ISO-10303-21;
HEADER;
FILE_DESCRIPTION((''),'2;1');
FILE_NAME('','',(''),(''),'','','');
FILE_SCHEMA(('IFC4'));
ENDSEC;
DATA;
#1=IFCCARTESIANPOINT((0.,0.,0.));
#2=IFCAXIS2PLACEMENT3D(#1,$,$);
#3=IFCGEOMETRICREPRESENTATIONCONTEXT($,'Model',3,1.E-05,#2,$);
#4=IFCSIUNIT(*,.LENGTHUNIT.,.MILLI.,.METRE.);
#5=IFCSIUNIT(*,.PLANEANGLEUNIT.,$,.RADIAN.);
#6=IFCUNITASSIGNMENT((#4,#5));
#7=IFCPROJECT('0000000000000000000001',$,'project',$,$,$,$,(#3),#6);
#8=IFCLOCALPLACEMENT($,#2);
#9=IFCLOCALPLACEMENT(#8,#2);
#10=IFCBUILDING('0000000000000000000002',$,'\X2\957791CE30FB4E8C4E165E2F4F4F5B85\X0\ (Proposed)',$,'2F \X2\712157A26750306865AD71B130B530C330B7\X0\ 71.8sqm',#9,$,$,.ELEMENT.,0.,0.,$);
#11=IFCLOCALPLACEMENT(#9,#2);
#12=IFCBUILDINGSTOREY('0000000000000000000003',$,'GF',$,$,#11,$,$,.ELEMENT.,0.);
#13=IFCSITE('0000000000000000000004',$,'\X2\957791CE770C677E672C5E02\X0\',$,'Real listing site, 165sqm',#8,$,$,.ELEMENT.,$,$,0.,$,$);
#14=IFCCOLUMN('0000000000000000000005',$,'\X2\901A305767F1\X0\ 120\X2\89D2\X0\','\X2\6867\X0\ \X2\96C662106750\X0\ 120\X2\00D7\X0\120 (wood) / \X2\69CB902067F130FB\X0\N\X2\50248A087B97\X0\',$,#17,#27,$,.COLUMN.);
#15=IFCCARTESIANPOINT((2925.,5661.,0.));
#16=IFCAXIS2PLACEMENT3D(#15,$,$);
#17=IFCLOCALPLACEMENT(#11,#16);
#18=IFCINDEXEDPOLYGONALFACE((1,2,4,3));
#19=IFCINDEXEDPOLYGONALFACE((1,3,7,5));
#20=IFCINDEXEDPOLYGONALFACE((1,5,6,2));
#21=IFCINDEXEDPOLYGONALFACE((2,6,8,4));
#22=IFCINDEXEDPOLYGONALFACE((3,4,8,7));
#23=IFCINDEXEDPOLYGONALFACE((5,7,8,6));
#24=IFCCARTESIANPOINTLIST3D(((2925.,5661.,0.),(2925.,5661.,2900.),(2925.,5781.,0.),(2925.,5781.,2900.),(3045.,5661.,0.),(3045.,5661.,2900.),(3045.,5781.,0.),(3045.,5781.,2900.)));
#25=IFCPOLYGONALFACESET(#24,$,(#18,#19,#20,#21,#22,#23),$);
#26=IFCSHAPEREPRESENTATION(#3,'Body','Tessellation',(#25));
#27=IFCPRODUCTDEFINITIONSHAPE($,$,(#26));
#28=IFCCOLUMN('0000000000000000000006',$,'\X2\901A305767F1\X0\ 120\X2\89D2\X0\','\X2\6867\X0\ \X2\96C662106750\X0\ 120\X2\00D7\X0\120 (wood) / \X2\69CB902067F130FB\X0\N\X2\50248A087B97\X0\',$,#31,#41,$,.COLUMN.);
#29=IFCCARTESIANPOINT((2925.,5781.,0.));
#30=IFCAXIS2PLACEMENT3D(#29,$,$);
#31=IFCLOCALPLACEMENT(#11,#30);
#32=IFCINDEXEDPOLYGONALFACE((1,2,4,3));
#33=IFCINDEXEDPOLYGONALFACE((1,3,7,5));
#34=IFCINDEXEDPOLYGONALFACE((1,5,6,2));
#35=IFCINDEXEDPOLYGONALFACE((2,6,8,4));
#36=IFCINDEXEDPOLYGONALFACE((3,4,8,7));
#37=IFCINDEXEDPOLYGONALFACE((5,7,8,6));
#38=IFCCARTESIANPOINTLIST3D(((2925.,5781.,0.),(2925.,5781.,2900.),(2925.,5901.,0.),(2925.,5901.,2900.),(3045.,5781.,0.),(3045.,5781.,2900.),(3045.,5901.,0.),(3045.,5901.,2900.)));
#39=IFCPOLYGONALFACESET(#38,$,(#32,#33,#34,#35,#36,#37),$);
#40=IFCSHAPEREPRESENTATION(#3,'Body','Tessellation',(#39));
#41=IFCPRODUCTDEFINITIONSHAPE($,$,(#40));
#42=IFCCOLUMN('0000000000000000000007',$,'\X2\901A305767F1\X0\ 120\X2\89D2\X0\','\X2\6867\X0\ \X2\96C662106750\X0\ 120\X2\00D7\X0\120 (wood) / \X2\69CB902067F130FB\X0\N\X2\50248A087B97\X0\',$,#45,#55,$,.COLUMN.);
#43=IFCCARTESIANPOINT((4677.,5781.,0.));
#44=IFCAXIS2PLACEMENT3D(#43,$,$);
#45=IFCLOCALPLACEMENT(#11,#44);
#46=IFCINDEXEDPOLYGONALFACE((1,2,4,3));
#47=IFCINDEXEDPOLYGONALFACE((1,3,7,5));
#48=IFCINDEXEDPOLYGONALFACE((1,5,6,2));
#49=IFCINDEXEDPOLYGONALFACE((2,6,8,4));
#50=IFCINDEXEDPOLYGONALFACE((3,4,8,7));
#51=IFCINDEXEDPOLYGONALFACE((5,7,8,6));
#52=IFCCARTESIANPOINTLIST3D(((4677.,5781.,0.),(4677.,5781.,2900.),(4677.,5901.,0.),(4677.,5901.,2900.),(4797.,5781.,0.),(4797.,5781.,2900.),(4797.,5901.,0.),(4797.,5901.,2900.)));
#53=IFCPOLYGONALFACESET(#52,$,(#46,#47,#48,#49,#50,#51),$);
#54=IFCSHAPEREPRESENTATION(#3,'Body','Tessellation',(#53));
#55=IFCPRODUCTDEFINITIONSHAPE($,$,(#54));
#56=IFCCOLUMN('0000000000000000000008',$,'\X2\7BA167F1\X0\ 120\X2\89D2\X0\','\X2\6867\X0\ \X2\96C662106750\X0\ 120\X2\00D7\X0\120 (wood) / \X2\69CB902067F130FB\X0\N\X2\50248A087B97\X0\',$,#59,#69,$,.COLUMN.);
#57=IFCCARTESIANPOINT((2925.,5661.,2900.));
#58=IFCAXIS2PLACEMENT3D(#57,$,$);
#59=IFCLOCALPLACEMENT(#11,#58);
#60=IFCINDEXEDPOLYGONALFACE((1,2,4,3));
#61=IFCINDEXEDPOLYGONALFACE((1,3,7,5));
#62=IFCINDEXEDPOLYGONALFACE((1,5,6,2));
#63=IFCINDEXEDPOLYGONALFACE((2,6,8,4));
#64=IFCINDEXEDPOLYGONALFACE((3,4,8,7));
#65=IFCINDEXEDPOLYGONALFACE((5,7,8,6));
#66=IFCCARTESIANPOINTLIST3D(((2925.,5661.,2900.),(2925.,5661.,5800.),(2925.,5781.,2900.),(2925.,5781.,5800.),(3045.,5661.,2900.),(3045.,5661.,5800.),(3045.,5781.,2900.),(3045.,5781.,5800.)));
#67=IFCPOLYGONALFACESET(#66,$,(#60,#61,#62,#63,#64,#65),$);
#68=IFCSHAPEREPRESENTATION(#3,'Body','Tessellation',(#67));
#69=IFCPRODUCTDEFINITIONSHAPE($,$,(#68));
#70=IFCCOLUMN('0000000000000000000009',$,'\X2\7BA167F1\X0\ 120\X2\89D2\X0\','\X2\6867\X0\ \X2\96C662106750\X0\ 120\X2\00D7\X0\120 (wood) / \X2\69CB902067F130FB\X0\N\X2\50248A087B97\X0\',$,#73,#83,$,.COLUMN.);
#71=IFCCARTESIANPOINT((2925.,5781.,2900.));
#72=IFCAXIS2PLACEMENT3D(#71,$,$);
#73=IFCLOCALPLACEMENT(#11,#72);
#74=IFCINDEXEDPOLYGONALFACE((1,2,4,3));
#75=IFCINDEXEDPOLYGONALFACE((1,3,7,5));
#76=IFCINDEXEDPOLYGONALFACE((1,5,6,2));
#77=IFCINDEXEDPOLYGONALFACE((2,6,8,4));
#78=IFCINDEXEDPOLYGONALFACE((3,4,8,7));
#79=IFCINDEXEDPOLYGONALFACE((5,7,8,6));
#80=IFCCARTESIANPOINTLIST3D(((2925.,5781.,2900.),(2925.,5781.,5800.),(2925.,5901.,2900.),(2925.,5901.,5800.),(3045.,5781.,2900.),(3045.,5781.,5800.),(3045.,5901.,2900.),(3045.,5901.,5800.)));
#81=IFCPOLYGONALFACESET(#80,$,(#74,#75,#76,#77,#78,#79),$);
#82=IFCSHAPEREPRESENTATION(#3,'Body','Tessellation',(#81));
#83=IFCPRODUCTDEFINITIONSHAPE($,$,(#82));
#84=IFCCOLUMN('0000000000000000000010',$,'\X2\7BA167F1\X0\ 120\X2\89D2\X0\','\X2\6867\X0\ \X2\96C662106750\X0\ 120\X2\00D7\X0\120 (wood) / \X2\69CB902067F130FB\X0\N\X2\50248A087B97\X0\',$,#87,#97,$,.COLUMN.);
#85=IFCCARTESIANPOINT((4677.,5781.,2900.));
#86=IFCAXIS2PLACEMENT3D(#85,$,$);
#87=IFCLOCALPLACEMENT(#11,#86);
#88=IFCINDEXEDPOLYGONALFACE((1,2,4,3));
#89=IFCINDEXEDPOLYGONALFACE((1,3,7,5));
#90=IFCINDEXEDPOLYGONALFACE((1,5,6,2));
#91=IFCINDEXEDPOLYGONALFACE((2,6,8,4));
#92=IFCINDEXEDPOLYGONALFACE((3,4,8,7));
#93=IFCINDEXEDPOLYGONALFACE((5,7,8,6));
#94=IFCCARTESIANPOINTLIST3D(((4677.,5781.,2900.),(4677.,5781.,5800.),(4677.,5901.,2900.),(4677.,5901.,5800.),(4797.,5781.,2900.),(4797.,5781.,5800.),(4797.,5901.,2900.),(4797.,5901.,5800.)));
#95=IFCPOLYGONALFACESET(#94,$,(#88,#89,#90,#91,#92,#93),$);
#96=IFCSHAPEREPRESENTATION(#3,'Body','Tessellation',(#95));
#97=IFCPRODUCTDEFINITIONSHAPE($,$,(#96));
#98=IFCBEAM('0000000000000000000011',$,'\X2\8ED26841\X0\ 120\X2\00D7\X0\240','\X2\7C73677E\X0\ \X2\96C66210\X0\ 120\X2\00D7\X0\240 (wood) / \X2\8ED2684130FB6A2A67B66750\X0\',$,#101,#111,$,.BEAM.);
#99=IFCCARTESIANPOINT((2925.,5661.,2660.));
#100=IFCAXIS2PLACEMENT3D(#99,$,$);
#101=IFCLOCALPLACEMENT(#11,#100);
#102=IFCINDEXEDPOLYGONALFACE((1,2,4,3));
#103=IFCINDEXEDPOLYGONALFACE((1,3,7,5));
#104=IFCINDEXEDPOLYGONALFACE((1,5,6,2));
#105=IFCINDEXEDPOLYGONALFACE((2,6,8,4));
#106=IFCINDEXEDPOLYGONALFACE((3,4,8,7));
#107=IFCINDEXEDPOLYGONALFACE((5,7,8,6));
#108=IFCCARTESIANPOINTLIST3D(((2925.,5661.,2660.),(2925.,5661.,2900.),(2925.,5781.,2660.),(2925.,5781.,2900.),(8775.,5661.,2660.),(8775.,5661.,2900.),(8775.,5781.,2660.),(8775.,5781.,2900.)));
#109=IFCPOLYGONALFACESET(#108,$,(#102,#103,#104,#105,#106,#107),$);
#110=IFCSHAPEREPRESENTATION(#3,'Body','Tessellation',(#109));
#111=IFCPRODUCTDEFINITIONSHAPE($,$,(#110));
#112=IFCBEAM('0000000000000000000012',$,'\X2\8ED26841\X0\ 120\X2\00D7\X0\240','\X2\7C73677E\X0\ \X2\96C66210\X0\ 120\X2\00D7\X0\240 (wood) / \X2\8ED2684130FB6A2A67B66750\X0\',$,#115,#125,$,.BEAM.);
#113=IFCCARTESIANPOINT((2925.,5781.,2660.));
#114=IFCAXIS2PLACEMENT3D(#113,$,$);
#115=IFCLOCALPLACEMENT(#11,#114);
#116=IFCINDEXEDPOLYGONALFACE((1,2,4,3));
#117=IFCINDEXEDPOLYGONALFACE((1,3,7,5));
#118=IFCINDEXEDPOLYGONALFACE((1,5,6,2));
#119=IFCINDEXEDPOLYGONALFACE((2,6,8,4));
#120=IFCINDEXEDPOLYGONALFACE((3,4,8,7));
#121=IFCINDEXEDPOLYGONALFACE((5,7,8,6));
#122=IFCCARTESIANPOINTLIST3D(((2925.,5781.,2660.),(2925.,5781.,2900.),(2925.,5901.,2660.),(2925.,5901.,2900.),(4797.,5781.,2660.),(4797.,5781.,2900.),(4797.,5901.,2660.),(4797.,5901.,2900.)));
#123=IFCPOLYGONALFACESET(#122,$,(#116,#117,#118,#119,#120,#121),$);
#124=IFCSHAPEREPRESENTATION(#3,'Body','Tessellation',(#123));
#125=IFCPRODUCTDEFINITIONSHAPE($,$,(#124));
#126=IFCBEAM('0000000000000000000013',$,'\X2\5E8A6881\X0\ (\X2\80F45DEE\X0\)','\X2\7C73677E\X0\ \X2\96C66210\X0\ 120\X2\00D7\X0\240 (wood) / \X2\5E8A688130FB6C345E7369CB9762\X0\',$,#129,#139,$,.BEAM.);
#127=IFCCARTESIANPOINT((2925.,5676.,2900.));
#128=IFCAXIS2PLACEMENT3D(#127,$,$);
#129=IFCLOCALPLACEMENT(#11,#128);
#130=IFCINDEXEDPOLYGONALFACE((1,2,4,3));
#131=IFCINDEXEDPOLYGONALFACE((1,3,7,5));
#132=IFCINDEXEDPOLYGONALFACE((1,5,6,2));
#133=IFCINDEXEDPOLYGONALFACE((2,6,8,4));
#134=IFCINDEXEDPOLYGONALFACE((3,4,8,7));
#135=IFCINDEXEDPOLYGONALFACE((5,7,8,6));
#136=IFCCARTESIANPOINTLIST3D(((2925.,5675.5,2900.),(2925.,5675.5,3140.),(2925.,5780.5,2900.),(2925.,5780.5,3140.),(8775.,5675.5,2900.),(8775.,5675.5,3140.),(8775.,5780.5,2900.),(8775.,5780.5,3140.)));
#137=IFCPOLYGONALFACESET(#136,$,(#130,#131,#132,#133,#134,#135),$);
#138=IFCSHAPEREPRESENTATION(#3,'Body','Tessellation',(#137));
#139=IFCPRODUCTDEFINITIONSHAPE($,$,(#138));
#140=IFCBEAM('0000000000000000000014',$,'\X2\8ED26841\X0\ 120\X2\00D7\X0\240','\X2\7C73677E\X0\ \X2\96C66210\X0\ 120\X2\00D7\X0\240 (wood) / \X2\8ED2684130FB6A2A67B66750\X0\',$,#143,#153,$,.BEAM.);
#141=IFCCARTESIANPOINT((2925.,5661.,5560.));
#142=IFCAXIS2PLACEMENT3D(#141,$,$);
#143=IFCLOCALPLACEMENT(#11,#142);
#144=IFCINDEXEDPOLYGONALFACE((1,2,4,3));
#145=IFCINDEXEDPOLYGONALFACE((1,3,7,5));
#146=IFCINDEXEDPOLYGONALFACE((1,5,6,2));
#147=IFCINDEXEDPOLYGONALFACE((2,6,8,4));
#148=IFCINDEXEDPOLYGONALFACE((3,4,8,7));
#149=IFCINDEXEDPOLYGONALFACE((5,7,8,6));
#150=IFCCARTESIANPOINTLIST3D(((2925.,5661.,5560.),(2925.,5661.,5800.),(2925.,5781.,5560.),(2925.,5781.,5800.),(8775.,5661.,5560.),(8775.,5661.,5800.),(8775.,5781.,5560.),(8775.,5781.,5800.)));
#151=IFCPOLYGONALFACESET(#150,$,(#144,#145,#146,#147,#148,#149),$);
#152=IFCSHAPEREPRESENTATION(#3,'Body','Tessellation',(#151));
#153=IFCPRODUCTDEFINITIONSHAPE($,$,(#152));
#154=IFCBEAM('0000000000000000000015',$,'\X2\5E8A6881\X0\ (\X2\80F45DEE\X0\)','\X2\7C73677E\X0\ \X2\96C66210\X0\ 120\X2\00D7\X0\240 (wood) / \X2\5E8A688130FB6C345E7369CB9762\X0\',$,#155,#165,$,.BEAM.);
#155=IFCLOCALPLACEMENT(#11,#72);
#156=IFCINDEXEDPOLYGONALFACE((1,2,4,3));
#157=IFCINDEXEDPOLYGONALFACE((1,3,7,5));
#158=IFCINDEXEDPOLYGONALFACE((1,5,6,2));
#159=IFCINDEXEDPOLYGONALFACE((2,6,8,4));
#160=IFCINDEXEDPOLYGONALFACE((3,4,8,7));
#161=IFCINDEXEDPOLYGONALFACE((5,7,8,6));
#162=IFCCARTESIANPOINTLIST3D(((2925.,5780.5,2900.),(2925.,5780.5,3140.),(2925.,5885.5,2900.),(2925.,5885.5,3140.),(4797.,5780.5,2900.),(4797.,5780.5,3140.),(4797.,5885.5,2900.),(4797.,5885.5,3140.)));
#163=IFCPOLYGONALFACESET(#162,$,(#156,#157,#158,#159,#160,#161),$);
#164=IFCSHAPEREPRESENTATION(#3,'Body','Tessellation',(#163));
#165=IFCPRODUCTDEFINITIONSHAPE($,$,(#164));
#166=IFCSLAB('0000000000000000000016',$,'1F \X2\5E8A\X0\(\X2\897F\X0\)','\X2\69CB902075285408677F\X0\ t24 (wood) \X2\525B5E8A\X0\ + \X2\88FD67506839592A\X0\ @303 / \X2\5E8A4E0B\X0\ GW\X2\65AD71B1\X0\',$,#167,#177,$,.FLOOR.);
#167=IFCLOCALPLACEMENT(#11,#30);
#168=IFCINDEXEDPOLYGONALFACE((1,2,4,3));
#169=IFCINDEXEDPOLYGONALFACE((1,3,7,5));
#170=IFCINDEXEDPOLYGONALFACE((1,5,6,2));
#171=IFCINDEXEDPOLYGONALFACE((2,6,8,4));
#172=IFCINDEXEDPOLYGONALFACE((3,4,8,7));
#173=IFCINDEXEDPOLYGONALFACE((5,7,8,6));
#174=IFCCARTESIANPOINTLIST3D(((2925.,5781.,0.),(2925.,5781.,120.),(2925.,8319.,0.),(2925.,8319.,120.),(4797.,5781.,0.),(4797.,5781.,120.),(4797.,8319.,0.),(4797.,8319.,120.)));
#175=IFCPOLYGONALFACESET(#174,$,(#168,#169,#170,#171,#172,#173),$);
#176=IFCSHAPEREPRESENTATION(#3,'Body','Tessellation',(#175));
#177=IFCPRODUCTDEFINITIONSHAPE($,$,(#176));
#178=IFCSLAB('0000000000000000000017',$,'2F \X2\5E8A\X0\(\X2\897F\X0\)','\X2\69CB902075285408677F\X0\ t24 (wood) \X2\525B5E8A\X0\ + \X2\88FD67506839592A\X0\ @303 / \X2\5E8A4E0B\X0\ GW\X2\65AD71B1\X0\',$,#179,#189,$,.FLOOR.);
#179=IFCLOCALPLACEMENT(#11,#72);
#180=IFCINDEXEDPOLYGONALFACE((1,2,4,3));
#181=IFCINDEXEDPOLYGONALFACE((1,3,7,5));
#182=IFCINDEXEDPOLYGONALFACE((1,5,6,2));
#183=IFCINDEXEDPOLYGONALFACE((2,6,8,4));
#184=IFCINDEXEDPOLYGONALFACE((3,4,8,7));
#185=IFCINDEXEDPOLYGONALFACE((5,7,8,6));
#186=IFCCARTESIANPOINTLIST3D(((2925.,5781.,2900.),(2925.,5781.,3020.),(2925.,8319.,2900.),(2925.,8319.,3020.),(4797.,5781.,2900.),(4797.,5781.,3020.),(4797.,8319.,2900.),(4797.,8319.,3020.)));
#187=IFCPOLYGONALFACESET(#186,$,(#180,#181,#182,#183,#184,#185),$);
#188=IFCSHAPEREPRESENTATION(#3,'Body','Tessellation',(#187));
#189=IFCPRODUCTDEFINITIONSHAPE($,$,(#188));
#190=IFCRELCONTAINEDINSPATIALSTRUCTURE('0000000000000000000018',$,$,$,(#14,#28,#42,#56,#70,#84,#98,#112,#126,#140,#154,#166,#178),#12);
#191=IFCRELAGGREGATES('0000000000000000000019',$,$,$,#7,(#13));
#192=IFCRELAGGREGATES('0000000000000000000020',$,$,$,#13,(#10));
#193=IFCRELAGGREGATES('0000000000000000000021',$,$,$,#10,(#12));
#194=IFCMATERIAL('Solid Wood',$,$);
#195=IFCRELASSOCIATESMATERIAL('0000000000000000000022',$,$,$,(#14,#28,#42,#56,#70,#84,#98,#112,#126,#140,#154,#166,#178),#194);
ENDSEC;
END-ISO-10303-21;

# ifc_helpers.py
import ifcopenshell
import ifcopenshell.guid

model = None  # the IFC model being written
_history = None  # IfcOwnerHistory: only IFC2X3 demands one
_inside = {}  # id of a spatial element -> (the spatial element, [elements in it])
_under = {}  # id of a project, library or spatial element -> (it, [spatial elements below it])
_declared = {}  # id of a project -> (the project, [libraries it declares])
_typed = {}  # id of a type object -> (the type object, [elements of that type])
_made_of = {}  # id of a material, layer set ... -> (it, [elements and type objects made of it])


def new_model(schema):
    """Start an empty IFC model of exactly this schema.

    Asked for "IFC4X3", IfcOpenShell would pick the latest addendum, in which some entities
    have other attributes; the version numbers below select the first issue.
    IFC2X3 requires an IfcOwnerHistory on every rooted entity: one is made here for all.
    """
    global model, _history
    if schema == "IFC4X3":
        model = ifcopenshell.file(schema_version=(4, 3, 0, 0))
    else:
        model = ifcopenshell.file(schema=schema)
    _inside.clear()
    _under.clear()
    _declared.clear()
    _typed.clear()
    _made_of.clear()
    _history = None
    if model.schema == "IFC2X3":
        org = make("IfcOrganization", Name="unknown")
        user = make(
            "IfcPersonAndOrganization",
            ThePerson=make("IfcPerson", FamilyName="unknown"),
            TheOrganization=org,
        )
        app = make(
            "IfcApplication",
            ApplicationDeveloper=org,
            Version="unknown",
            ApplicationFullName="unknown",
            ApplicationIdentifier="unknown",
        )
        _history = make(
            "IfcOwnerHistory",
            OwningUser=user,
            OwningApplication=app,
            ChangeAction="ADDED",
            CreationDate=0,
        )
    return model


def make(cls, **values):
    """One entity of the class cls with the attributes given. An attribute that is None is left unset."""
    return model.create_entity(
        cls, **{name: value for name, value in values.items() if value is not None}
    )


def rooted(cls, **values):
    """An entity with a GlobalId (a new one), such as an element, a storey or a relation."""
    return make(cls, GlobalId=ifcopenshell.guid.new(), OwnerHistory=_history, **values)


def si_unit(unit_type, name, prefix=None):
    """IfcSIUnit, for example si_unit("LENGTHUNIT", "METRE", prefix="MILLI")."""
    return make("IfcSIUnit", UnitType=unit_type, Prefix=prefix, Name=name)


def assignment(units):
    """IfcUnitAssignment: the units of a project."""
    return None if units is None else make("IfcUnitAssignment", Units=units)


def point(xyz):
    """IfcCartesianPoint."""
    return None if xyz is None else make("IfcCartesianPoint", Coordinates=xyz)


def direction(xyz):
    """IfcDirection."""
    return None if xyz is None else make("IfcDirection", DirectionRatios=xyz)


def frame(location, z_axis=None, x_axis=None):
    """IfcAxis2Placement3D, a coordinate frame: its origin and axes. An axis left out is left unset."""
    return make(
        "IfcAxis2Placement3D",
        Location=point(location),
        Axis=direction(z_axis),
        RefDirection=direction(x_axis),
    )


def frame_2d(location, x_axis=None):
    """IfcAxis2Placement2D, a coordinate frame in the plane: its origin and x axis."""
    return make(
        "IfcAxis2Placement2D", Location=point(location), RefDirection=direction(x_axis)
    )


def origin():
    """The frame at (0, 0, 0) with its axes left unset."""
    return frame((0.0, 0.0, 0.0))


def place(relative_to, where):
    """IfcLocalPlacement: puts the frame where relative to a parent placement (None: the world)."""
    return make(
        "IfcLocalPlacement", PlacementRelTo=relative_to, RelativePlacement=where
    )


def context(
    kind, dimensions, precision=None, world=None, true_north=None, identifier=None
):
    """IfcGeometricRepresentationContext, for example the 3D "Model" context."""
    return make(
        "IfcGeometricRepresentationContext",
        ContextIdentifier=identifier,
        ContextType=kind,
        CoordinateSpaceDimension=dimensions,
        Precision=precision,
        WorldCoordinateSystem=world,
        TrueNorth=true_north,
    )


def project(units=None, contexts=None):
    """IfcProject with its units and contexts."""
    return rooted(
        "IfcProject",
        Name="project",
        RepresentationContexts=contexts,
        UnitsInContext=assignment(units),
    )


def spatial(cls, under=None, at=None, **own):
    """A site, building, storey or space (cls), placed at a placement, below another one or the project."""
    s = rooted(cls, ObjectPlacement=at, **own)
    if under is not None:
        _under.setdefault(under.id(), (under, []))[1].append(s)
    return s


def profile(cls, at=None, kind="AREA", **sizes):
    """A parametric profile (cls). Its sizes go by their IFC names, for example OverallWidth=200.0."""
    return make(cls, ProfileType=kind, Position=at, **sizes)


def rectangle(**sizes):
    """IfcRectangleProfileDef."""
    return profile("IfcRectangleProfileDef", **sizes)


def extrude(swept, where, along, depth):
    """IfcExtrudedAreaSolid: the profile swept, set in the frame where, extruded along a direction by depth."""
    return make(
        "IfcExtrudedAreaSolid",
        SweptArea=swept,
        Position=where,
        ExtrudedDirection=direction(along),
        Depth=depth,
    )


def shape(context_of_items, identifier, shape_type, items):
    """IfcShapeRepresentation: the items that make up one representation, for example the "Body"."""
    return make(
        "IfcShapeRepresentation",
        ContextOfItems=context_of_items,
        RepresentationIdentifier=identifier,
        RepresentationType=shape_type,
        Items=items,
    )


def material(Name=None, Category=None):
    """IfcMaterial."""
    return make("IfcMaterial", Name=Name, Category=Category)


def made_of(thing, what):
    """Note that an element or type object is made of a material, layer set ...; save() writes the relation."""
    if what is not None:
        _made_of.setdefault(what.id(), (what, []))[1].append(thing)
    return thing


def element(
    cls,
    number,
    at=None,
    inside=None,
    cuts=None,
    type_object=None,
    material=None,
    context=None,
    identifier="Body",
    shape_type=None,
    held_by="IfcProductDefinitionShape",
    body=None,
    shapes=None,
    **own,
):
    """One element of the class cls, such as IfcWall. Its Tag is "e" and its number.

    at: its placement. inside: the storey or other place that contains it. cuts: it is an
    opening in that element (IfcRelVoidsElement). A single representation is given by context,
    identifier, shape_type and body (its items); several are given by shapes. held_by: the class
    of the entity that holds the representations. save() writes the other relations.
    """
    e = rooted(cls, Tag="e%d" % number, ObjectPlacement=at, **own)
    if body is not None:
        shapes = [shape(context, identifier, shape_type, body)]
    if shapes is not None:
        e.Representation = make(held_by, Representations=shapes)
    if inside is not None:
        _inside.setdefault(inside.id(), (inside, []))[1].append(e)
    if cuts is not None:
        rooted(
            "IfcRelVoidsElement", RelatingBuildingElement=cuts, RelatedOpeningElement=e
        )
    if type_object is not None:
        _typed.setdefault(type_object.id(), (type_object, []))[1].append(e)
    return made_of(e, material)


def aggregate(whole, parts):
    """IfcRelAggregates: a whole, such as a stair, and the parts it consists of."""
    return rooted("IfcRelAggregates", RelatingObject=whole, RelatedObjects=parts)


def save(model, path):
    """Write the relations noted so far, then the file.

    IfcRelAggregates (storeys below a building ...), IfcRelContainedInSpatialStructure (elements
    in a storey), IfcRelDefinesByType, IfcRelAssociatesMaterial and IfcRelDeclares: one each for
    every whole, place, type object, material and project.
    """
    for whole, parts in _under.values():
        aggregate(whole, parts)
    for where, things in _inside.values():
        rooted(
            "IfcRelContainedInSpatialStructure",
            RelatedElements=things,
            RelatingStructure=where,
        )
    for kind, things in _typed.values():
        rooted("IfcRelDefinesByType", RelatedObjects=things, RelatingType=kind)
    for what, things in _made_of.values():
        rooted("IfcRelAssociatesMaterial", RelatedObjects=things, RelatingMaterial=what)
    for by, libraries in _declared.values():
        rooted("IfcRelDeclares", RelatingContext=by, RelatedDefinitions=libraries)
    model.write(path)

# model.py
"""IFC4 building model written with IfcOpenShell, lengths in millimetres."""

from ifc_helpers import new_model, si_unit, frame, frame_2d, origin, place, context, project, spatial, rectangle, extrude, material, element, save


model = new_model("IFC4")

# Units and contexts
model_context = context("Model", 3, precision=1e-05, world=origin())
ifc_project = project(units=[si_unit("LENGTHUNIT", "METRE", prefix="MILLI"), si_unit("PLANEANGLEUNIT", "RADIAN")], contexts=[model_context])

# Site, building, storey
site_placement = place(None, origin())
site = spatial("IfcSite", under=ifc_project, at=site_placement, Name="長野県松本市", ObjectType="Real listing site, 165sqm", CompositionType="ELEMENT", RefElevation=0.0)
building_placement = place(site_placement, origin())
building = spatial("IfcBuilding", under=site, at=building_placement, Name="長野・二世帯住宅 (Proposed)", ObjectType="2F 無垢材と断熱サッシ 71.8sqm", CompositionType="ELEMENT", ElevationOfRefHeight=0.0, ElevationOfTerrain=0.0)
storey_placement = place(building_placement, origin())
storey = spatial("IfcBuildingStorey", under=building, at=storey_placement, Name="GF", CompositionType="ELEMENT", Elevation=0.0)

# Columns
ifc_material_1 = material(Name="Solid Wood")
column_1_placement = place(storey_placement, frame((2925.0, 5661.0, 0.0)))
element("IfcColumn", 1, at=column_1_placement, inside=storey, material=ifc_material_1, Name="通し柱 120角", Description="桧 集成材 120×120 (wood) / 構造柱・N値計算", PredefinedType="COLUMN", context=model_context, shape_type="SweptSolid", body=[
    extrude(rectangle(XDim=120.0, YDim=120.0, at=frame_2d((60.0, 60.0))), frame((2925.0, 5661.0, 0.0)), (0.0, 0.0, 1.0), 2900.0),
])
column_2_placement = place(storey_placement, frame((2925.0, 5781.0, 0.0)))
element("IfcColumn", 2, at=column_2_placement, inside=storey, material=ifc_material_1, Name="通し柱 120角", Description="桧 集成材 120×120 (wood) / 構造柱・N値計算", PredefinedType="COLUMN", context=model_context, shape_type="SweptSolid", body=[
    extrude(rectangle(XDim=120.0, YDim=120.0, at=frame_2d((60.0, 60.0))), frame((2925.0, 5781.0, 0.0)), (0.0, 0.0, 1.0), 2900.0),
])
column_3_placement = place(storey_placement, frame((4677.0, 5781.0, 0.0)))
element("IfcColumn", 3, at=column_3_placement, inside=storey, material=ifc_material_1, Name="通し柱 120角", Description="桧 集成材 120×120 (wood) / 構造柱・N値計算", PredefinedType="COLUMN", context=model_context, shape_type="SweptSolid", body=[
    extrude(rectangle(XDim=120.0, YDim=120.0, at=frame_2d((60.0, 60.0))), frame((4677.0, 5781.0, 0.0)), (0.0, 0.0, 1.0), 2900.0),
])
column_4_placement = place(storey_placement, frame((2925.0, 5661.0, 2900.0)))
element("IfcColumn", 4, at=column_4_placement, inside=storey, material=ifc_material_1, Name="管柱 120角", Description="桧 集成材 120×120 (wood) / 構造柱・N値計算", PredefinedType="COLUMN", context=model_context, shape_type="SweptSolid", body=[
    extrude(rectangle(XDim=120.0, YDim=120.0, at=frame_2d((60.0, 60.0))), frame((2925.0, 5661.0, 2900.0)), (0.0, 0.0, 1.0), 2900.0),
])
column_5_placement = place(storey_placement, frame((2925.0, 5781.0, 2900.0)))
element("IfcColumn", 5, at=column_5_placement, inside=storey, material=ifc_material_1, Name="管柱 120角", Description="桧 集成材 120×120 (wood) / 構造柱・N値計算", PredefinedType="COLUMN", context=model_context, shape_type="SweptSolid", body=[
    extrude(rectangle(XDim=120.0, YDim=120.0, at=frame_2d((60.0, 60.0))), frame((2925.0, 5781.0, 2900.0)), (0.0, 0.0, 1.0), 2900.0),
])
column_6_placement = place(storey_placement, frame((4677.0, 5781.0, 2900.0)))
element("IfcColumn", 6, at=column_6_placement, inside=storey, material=ifc_material_1, Name="管柱 120角", Description="桧 集成材 120×120 (wood) / 構造柱・N値計算", PredefinedType="COLUMN", context=model_context, shape_type="SweptSolid", body=[
    extrude(rectangle(XDim=120.0, YDim=120.0, at=frame_2d((60.0, 60.0))), frame((4677.0, 5781.0, 2900.0)), (0.0, 0.0, 1.0), 2900.0),
])

# Beams
beam_1_placement = place(storey_placement, frame((2925.0, 5661.0, 2660.0)))
element("IfcBeam", 7, at=beam_1_placement, inside=storey, material=ifc_material_1, Name="軒桁 120×240", Description="米松 集成 120×240 (wood) / 軒桁・横架材", PredefinedType="BEAM", context=model_context, shape_type="SweptSolid", body=[
    extrude(rectangle(XDim=5850.0, YDim=120.0, at=frame_2d((2925.0, 60.0))), frame((2925.0, 5661.0, 2660.0)), (0.0, 0.0, 1.0), 240.0),
])
beam_2_placement = place(storey_placement, frame((2925.0, 5781.0, 2660.0)))
element("IfcBeam", 8, at=beam_2_placement, inside=storey, material=ifc_material_1, Name="軒桁 120×240", Description="米松 集成 120×240 (wood) / 軒桁・横架材", PredefinedType="BEAM", context=model_context, shape_type="SweptSolid", body=[
    extrude(rectangle(XDim=1872.0, YDim=120.0, at=frame_2d((936.0, 60.0))), frame((2925.0, 5781.0, 2660.0)), (0.0, 0.0, 1.0), 240.0),
])
beam_3_placement = place(storey_placement, frame((2925.0, 5676.0, 2900.0)))
element("IfcBeam", 9, at=beam_3_placement, inside=storey, material=ifc_material_1, Name="床梁 (胴差)", Description="米松 集成 120×240 (wood) / 床梁・水平構面", PredefinedType="BEAM", context=model_context, shape_type="SweptSolid", body=[
    extrude(rectangle(XDim=5850.0, YDim=105.0, at=frame_2d((2925.0, 52.0))), frame((2925.0, 5676.0, 2900.0)), (0.0, 0.0, 1.0), 240.0),
])
beam_4_placement = place(storey_placement, frame((2925.0, 5661.0, 5560.0)))
element("IfcBeam", 10, at=beam_4_placement, inside=storey, material=ifc_material_1, Name="軒桁 120×240", Description="米松 集成 120×240 (wood) / 軒桁・横架材", PredefinedType="BEAM", context=model_context, shape_type="SweptSolid", body=[
    extrude(rectangle(XDim=5850.0, YDim=120.0, at=frame_2d((2925.0, 60.0))), frame((2925.0, 5661.0, 5560.0)), (0.0, 0.0, 1.0), 240.0),
])
beam_5_placement = place(storey_placement, frame((2925.0, 5781.0, 2900.0)))
element("IfcBeam", 11, at=beam_5_placement, inside=storey, material=ifc_material_1, Name="床梁 (胴差)", Description="米松 集成 120×240 (wood) / 床梁・水平構面", PredefinedType="BEAM", context=model_context, shape_type="SweptSolid", body=[
    extrude(rectangle(XDim=1872.0, YDim=105.0, at=frame_2d((936.0, 52.0))), frame((2925.0, 5781.0, 2900.0)), (0.0, 0.0, 1.0), 240.0),
])

# Slabs
slab_1_placement = place(storey_placement, frame((2925.0, 5781.0, 0.0)))
element("IfcSlab", 12, at=slab_1_placement, inside=storey, material=ifc_material_1, Name="1F 床(西)", Description="構造用合板 t24 (wood) 剛床 + 製材根太 @303 / 床下 GW断熱", PredefinedType="FLOOR", context=model_context, shape_type="SweptSolid", body=[
    extrude(rectangle(XDim=1872.0, YDim=2538.0, at=frame_2d((936.0, 1269.0))), frame((2925.0, 5781.0, 0.0)), (0.0, 0.0, 1.0), 120.0),
])
slab_2_placement = place(storey_placement, frame((2925.0, 5781.0, 2900.0)))
element("IfcSlab", 13, at=slab_2_placement, inside=storey, material=ifc_material_1, Name="2F 床(西)", Description="構造用合板 t24 (wood) 剛床 + 製材根太 @303 / 床下 GW断熱", PredefinedType="FLOOR", context=model_context, shape_type="SweptSolid", body=[
    extrude(rectangle(XDim=1872.0, YDim=2538.0, at=frame_2d((936.0, 1269.0))), frame((2925.0, 5781.0, 2900.0)), (0.0, 0.0, 1.0), 120.0),
])

save(model, "model.ifc")
